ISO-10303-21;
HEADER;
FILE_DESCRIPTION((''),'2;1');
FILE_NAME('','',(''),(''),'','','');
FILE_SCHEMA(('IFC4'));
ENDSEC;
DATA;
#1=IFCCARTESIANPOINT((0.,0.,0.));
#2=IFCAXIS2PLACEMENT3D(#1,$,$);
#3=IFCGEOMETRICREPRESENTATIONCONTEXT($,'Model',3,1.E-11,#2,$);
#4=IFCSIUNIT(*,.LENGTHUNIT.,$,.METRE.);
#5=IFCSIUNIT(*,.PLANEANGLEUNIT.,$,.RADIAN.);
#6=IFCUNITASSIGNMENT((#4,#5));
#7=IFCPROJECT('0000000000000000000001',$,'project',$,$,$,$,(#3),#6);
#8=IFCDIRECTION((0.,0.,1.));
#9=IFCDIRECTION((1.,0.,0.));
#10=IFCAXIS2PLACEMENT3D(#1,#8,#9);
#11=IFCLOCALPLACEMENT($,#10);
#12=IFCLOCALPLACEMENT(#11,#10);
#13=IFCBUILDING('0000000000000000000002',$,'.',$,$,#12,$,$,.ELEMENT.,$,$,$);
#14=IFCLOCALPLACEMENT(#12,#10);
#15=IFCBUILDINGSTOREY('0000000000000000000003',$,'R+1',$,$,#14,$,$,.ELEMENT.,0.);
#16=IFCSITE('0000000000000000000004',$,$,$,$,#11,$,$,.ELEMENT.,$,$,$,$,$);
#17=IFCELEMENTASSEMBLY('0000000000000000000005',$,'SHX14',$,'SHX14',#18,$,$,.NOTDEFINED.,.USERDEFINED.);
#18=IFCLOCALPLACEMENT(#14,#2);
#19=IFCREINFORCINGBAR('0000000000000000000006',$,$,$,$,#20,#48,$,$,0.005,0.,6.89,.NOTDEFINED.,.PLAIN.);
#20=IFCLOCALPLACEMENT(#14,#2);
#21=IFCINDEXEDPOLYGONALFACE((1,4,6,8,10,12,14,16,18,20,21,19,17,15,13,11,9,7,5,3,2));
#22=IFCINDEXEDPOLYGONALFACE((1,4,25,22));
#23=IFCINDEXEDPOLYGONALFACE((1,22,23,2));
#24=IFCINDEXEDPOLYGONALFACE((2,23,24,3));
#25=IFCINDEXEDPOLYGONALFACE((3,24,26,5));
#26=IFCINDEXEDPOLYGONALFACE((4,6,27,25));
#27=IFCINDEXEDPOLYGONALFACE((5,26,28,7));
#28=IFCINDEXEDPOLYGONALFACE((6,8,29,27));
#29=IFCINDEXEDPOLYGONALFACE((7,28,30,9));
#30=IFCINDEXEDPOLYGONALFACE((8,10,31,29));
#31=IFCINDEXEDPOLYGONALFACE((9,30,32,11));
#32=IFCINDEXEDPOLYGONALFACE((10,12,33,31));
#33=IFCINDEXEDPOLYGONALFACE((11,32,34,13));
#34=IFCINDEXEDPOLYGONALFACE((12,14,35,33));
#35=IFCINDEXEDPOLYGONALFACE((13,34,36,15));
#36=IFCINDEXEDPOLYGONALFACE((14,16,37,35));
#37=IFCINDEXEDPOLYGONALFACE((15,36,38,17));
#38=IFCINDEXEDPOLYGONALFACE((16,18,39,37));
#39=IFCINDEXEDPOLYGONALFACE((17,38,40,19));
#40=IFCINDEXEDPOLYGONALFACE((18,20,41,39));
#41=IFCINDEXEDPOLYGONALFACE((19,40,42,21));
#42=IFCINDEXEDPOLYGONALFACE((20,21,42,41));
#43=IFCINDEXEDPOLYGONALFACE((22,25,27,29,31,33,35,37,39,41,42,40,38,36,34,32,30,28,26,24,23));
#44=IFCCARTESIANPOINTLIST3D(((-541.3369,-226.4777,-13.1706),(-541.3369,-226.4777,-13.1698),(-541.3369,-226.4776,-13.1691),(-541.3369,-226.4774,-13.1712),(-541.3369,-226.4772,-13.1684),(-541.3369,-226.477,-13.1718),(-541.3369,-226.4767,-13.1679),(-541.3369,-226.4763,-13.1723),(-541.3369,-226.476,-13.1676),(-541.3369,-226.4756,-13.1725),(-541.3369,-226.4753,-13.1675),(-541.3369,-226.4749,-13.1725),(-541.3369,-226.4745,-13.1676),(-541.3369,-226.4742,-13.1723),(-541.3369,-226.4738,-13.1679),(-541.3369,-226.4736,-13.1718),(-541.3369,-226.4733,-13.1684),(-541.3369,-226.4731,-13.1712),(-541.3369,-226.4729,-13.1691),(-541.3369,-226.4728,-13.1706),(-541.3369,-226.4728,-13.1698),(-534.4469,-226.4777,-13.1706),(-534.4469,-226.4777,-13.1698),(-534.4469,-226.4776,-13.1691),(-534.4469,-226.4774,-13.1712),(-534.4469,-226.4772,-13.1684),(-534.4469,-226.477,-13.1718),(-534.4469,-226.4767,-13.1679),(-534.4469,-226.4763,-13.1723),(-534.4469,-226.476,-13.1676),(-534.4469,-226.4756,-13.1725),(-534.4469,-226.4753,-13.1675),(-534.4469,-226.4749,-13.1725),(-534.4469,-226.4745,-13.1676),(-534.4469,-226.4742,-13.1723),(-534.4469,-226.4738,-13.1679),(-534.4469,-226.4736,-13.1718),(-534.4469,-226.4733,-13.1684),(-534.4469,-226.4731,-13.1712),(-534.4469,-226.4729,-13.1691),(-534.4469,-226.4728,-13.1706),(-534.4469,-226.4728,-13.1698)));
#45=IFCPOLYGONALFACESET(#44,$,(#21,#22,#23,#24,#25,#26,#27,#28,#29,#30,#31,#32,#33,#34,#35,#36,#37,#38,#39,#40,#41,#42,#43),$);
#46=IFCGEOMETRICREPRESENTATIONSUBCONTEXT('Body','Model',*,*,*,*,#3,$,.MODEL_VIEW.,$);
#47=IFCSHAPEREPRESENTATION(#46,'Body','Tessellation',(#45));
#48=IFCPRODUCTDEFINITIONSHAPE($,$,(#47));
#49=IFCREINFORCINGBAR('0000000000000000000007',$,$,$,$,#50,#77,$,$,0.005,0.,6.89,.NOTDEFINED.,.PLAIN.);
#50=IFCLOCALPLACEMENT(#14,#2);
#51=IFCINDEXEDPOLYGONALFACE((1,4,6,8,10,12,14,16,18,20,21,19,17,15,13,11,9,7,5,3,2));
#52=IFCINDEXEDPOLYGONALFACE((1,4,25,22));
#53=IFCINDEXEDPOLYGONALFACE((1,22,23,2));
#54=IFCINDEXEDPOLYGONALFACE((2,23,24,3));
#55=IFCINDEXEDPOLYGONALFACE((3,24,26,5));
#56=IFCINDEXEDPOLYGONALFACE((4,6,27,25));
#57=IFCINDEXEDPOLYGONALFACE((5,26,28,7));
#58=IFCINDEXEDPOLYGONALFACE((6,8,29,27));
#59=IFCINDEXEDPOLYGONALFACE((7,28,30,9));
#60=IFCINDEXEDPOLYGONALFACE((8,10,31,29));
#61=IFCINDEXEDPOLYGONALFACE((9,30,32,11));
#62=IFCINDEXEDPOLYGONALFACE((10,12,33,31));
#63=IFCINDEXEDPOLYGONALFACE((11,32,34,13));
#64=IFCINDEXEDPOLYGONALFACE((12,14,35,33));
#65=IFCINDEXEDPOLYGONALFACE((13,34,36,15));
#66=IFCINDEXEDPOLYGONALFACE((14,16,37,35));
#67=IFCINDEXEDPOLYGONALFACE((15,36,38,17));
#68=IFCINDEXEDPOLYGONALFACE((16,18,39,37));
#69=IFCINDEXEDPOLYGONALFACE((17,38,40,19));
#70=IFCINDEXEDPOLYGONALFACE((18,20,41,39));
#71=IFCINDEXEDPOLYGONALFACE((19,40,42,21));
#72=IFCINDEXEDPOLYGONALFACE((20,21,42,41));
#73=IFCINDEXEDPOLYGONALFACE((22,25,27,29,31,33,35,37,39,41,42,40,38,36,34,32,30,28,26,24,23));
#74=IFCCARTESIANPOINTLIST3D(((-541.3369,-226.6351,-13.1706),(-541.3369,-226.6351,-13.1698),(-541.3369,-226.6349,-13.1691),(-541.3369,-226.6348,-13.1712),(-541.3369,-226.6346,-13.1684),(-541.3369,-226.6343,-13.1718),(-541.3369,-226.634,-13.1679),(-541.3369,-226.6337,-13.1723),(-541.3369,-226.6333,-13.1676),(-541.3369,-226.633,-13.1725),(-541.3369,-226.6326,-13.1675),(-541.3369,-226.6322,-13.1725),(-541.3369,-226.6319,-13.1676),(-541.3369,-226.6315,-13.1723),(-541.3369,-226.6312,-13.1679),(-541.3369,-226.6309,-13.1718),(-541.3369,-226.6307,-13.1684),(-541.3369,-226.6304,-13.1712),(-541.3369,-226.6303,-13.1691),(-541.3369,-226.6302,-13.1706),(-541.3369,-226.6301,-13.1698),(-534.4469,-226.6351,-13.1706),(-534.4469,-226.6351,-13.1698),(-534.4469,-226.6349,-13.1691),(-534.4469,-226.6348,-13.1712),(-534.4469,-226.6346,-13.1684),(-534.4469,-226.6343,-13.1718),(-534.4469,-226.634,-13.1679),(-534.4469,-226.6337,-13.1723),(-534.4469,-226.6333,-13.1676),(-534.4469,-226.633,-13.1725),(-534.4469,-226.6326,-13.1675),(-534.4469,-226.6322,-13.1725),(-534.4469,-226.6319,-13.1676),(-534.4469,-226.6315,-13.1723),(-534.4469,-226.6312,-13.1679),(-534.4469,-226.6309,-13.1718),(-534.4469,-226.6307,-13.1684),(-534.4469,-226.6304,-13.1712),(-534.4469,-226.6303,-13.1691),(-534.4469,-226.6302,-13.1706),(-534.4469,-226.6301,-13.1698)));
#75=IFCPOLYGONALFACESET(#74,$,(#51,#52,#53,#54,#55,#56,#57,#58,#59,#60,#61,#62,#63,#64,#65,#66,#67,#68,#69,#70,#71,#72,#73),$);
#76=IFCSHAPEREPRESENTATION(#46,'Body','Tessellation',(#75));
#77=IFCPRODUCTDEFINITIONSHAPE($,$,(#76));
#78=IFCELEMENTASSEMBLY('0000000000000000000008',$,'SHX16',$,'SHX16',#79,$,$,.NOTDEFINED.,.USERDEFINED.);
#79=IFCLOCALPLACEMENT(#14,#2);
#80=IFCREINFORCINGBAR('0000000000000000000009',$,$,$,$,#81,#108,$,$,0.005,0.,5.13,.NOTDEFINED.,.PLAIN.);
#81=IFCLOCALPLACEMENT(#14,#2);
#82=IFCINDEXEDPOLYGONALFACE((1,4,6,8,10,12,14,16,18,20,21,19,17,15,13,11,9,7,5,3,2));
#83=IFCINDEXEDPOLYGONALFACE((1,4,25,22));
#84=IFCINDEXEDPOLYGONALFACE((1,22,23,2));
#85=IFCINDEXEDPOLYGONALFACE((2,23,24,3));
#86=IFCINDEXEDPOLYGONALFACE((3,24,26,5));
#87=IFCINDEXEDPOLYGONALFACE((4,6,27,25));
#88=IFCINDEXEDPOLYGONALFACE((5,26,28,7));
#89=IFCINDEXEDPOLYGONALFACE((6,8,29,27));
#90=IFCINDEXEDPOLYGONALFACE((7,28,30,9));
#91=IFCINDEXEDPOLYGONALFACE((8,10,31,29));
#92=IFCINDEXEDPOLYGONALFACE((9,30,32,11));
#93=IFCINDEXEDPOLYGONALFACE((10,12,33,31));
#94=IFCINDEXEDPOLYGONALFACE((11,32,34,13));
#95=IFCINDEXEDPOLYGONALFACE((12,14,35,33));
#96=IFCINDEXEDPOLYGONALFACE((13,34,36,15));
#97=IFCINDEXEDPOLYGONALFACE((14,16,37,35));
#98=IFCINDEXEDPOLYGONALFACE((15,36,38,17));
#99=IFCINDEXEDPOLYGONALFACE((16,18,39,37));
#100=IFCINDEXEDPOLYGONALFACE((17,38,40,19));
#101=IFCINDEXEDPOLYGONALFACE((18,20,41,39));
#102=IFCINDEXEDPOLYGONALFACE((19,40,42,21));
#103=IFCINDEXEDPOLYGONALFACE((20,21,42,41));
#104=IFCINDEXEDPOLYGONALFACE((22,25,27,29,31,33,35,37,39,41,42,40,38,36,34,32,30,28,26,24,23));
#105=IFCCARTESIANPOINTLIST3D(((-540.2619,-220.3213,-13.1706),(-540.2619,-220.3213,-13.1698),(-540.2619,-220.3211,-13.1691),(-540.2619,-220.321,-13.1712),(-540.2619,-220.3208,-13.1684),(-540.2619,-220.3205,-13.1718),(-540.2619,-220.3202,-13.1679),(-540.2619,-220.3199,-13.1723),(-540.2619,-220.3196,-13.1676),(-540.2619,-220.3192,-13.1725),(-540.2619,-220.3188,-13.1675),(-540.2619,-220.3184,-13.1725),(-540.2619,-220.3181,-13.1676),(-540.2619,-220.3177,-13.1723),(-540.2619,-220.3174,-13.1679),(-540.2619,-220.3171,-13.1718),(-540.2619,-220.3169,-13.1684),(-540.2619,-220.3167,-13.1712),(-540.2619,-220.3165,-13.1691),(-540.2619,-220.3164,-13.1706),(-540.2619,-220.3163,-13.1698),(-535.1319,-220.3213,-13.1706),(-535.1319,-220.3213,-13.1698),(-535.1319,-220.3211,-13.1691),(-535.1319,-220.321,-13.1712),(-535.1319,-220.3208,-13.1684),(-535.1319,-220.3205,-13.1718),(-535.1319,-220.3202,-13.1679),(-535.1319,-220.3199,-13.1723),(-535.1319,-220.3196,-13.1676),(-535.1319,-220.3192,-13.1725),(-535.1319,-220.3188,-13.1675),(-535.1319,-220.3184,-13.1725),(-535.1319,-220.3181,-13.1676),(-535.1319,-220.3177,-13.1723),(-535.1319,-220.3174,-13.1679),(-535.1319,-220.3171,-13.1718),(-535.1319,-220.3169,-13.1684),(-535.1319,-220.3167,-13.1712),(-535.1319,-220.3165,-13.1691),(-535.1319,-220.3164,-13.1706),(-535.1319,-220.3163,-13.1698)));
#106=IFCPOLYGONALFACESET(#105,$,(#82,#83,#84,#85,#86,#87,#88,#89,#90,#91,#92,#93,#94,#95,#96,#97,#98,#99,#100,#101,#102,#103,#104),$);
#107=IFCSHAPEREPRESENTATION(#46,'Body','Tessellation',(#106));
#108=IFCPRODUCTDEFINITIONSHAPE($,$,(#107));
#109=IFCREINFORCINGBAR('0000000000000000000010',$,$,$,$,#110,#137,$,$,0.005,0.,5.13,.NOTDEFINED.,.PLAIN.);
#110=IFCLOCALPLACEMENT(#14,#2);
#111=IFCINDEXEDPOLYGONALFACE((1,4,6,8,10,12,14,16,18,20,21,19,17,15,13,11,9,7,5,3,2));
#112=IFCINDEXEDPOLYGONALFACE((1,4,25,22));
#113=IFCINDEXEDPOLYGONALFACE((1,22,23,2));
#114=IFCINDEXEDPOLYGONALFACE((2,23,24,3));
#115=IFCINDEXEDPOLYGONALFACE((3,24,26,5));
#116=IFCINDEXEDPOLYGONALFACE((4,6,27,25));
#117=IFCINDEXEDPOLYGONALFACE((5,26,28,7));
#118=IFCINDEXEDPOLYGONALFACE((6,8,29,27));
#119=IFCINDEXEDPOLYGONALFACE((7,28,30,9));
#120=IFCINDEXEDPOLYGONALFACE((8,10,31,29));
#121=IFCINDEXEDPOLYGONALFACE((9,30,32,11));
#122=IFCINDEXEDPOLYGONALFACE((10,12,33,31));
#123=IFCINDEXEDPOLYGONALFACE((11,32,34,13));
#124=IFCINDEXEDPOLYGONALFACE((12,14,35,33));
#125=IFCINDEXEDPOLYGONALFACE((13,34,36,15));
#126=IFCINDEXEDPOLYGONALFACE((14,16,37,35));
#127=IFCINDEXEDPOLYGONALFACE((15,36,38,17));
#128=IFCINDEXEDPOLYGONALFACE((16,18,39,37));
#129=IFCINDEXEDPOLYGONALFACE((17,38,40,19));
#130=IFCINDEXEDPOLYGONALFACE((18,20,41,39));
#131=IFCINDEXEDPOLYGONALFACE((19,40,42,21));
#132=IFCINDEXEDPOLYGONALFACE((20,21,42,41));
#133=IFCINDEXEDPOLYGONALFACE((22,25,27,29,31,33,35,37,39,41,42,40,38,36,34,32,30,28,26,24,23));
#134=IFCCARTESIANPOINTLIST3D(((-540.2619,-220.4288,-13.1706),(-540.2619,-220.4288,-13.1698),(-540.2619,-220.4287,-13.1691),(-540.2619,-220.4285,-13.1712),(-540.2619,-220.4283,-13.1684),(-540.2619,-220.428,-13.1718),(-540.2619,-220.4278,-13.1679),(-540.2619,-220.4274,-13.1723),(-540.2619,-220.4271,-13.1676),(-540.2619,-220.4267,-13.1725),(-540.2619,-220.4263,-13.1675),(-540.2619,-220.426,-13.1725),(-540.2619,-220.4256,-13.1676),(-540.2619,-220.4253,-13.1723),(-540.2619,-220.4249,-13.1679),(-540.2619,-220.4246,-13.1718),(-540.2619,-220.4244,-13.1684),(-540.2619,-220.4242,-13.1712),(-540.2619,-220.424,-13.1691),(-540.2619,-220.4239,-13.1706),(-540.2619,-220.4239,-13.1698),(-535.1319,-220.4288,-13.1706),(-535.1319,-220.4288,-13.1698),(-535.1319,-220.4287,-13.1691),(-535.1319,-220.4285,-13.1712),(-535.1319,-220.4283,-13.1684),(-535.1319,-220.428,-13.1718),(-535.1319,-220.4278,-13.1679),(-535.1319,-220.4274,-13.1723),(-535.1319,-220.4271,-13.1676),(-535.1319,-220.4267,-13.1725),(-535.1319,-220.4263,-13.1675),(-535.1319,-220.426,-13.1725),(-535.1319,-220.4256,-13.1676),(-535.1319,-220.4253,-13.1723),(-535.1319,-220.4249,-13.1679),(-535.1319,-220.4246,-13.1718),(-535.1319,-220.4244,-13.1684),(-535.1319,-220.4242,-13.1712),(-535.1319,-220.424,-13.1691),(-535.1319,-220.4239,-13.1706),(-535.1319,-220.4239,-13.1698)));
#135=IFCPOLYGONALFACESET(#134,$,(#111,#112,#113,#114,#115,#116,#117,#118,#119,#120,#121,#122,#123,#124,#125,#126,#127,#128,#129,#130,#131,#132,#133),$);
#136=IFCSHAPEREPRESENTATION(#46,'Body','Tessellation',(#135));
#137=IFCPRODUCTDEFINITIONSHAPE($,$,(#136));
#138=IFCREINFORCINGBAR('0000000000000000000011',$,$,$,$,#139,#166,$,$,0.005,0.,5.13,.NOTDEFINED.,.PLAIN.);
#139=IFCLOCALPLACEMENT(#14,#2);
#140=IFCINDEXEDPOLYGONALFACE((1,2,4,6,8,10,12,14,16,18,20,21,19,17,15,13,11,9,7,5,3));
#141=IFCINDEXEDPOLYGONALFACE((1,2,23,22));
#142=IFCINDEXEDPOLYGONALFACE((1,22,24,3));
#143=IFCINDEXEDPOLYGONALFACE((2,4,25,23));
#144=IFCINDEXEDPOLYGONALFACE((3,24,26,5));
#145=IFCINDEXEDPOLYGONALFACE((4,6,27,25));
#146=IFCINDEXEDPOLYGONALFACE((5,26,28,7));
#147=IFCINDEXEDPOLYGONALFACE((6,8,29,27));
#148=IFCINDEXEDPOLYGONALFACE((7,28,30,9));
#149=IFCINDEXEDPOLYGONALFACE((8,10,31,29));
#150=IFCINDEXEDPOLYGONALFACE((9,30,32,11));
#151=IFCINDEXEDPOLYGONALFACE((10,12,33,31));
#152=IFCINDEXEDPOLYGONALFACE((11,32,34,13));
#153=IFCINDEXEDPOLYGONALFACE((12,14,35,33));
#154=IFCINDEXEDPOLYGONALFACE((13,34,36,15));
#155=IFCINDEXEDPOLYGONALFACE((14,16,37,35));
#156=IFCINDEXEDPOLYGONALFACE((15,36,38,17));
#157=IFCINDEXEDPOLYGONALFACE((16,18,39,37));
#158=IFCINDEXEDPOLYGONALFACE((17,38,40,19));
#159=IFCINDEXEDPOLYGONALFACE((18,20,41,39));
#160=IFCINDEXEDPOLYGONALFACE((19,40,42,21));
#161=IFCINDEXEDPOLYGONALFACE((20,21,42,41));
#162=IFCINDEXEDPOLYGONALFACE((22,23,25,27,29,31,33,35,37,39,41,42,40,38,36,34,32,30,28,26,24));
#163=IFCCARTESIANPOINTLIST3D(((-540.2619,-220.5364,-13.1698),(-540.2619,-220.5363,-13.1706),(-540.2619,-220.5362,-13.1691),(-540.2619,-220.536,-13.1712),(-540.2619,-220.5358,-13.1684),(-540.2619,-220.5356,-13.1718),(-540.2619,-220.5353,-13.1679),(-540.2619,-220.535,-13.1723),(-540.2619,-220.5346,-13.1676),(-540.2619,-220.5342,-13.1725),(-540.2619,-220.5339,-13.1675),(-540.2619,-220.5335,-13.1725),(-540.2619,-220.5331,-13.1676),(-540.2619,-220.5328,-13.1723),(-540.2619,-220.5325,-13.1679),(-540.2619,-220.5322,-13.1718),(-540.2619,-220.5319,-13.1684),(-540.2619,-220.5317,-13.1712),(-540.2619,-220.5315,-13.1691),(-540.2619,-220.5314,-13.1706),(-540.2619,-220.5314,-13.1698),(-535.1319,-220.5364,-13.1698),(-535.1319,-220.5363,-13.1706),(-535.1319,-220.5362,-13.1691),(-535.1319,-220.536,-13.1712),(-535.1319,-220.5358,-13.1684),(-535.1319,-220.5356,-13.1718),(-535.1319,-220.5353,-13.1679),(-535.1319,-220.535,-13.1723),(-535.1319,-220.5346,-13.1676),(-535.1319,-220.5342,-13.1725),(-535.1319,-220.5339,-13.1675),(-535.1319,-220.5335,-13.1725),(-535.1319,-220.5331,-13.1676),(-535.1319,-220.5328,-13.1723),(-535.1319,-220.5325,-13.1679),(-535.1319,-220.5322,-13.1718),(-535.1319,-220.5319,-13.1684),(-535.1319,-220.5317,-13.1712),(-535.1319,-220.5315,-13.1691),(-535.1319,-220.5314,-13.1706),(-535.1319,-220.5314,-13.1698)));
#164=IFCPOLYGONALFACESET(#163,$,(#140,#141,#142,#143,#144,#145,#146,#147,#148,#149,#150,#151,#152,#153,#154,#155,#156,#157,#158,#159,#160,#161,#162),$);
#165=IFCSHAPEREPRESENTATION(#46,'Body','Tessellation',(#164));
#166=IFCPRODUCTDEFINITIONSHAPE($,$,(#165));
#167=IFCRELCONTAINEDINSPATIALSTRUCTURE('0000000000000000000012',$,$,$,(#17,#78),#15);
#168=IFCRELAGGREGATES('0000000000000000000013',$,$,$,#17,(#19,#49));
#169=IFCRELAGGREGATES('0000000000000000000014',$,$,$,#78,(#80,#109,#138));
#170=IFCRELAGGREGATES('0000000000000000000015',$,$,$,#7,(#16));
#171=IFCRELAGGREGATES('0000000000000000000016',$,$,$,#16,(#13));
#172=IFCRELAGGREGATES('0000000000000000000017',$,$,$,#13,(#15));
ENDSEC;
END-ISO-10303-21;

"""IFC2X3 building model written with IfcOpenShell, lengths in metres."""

from ifc_helpers import new_model, entity, si_unit, origin, origin_with_axes, place, context, subcontext, project, spatial, shape, element, aggregate, save


model = new_model("IFC2X3")

# Units and contexts
model_context = context("Model", 3, precision=1e-11, world=origin())
body_context = subcontext(model_context, "Body", "Model", "MODEL_VIEW")
ifc_project = project(units=[si_unit("LENGTHUNIT", "METRE"), si_unit("PLANEANGLEUNIT", "RADIAN")], contexts=[model_context])

# Site, building, storey
site_placement = place(None, origin_with_axes())
site = spatial("IfcSite", under=ifc_project, at=site_placement, CompositionType="ELEMENT")
building_placement = place(site_placement, origin_with_axes())
building = spatial("IfcBuilding", under=site, at=building_placement, Name=".", CompositionType="ELEMENT")
storey_placement = place(building_placement, origin_with_axes())
storey = spatial("IfcBuildingStorey", under=building, at=storey_placement, Name="R+1", CompositionType="ELEMENT", Elevation=0.0)

# Element assemblies, reinforcing bars
assembly_1_placement = place(storey_placement, origin_with_axes())
assembly_1 = element("IfcElementAssembly", 1, at=assembly_1_placement, inside=storey, Name="SHX14", ObjectType="SHX14", AssemblyPlace="NOTDEFINED", PredefinedType="USERDEFINED")
reinforcing_bar_1_placement = place(assembly_1_placement, origin_with_axes())
reinforcing_bar_1 = element("IfcReinforcingBar", 2, at=reinforcing_bar_1_placement, BarLength=6.89, BarRole="NOTDEFINED", BarSurface="PLAIN", CrossSectionArea=0.0, NominalDiameter=0.005, shapes=[
    shape(body_context, "Body", "AdvancedSweptSolid", [entity("IfcSweptDiskSolid", entity("IfcPolyline", [entity("IfcCartesianPoint", [534.4469, 226.4753, 13.17]), entity("IfcCartesianPoint", [541.3369, 226.4753, 13.17])]), 0.0025, None, 0.0, 6.89)]),
    shape(body_context, "Body", "AdvancedSweptSolid", [entity("IfcSweptDiskSolid", entity("IfcPolyline", [entity("IfcCartesianPoint", [534.4469, 226.4753, 13.17]), entity("IfcCartesianPoint", [541.3369, 226.4753, 13.17])]), 0.0025, None, 0.0, 6.89)]),
])
reinforcing_bar_2_placement = place(assembly_1_placement, origin_with_axes())
reinforcing_bar_2 = element("IfcReinforcingBar", 3, at=reinforcing_bar_2_placement, BarLength=6.89, BarRole="NOTDEFINED", BarSurface="PLAIN", CrossSectionArea=0.0, NominalDiameter=0.005, shapes=[
    shape(body_context, "Body", "AdvancedSweptSolid", [entity("IfcSweptDiskSolid", entity("IfcPolyline", [entity("IfcCartesianPoint", [534.4469, 226.6326, 13.17]), entity("IfcCartesianPoint", [541.3369, 226.6326, 13.17])]), 0.0025, None, 0.0, 6.89)]),
    shape(body_context, "Body", "AdvancedSweptSolid", [entity("IfcSweptDiskSolid", entity("IfcPolyline", [entity("IfcCartesianPoint", [534.4469, 226.6326, 13.17]), entity("IfcCartesianPoint", [541.3369, 226.6326, 13.17])]), 0.0025, None, 0.0, 6.89)]),
])
aggregate(assembly_1, [reinforcing_bar_1, reinforcing_bar_2])
assembly_2_placement = place(storey_placement, origin_with_axes())
assembly_2 = element("IfcElementAssembly", 4, at=assembly_2_placement, inside=storey, Name="SHX16", ObjectType="SHX16", AssemblyPlace="NOTDEFINED", PredefinedType="USERDEFINED")
reinforcing_bar_3_placement = place(assembly_2_placement, origin_with_axes())
reinforcing_bar_3 = element("IfcReinforcingBar", 5, at=reinforcing_bar_3_placement, BarLength=5.13, BarRole="NOTDEFINED", BarSurface="PLAIN", CrossSectionArea=0.0, NominalDiameter=0.005, shapes=[
    shape(body_context, "Body", "AdvancedSweptSolid", [entity("IfcSweptDiskSolid", entity("IfcPolyline", [entity("IfcCartesianPoint", [535.1319, 220.3188, 13.17]), entity("IfcCartesianPoint", [540.2619, 220.3188, 13.17])]), 0.0025, None, 0.0, 5.13)]),
    shape(body_context, "Body", "AdvancedSweptSolid", [entity("IfcSweptDiskSolid", entity("IfcPolyline", [entity("IfcCartesianPoint", [535.1319, 220.3188, 13.17]), entity("IfcCartesianPoint", [540.2619, 220.3188, 13.17])]), 0.0025, None, 0.0, 5.13)]),
])
reinforcing_bar_4_placement = place(assembly_2_placement, origin_with_axes())
reinforcing_bar_4 = element("IfcReinforcingBar", 6, at=reinforcing_bar_4_placement, BarLength=5.13, BarRole="NOTDEFINED", BarSurface="PLAIN", CrossSectionArea=0.0, NominalDiameter=0.005, shapes=[
    shape(body_context, "Body", "AdvancedSweptSolid", [entity("IfcSweptDiskSolid", entity("IfcPolyline", [entity("IfcCartesianPoint", [535.1319, 220.4263, 13.17]), entity("IfcCartesianPoint", [540.2619, 220.4263, 13.17])]), 0.0025, None, 0.0, 5.13)]),
    shape(body_context, "Body", "AdvancedSweptSolid", [entity("IfcSweptDiskSolid", entity("IfcPolyline", [entity("IfcCartesianPoint", [535.1319, 220.4263, 13.17]), entity("IfcCartesianPoint", [540.2619, 220.4263, 13.17])]), 0.0025, None, 0.0, 5.13)]),
])
reinforcing_bar_5_placement = place(assembly_2_placement, origin_with_axes())
reinforcing_bar_5 = element("IfcReinforcingBar", 7, at=reinforcing_bar_5_placement, BarLength=5.13, BarRole="NOTDEFINED", BarSurface="PLAIN", CrossSectionArea=0.0, NominalDiameter=0.005, shapes=[
    shape(body_context, "Body", "AdvancedSweptSolid", [entity("IfcSweptDiskSolid", entity("IfcPolyline", [entity("IfcCartesianPoint", [535.1319, 220.5339, 13.17]), entity("IfcCartesianPoint", [540.2619, 220.5339, 13.17])]), 0.0025, None, 0.0, 5.13)]),
    shape(body_context, "Body", "AdvancedSweptSolid", [entity("IfcSweptDiskSolid", entity("IfcPolyline", [entity("IfcCartesianPoint", [535.1319, 220.5339, 13.17]), entity("IfcCartesianPoint", [540.2619, 220.5339, 13.17])]), 0.0025, None, 0.0, 5.13)]),
])
aggregate(assembly_2, [reinforcing_bar_3, reinforcing_bar_4, reinforcing_bar_5])

save(model, "model.ifc")
